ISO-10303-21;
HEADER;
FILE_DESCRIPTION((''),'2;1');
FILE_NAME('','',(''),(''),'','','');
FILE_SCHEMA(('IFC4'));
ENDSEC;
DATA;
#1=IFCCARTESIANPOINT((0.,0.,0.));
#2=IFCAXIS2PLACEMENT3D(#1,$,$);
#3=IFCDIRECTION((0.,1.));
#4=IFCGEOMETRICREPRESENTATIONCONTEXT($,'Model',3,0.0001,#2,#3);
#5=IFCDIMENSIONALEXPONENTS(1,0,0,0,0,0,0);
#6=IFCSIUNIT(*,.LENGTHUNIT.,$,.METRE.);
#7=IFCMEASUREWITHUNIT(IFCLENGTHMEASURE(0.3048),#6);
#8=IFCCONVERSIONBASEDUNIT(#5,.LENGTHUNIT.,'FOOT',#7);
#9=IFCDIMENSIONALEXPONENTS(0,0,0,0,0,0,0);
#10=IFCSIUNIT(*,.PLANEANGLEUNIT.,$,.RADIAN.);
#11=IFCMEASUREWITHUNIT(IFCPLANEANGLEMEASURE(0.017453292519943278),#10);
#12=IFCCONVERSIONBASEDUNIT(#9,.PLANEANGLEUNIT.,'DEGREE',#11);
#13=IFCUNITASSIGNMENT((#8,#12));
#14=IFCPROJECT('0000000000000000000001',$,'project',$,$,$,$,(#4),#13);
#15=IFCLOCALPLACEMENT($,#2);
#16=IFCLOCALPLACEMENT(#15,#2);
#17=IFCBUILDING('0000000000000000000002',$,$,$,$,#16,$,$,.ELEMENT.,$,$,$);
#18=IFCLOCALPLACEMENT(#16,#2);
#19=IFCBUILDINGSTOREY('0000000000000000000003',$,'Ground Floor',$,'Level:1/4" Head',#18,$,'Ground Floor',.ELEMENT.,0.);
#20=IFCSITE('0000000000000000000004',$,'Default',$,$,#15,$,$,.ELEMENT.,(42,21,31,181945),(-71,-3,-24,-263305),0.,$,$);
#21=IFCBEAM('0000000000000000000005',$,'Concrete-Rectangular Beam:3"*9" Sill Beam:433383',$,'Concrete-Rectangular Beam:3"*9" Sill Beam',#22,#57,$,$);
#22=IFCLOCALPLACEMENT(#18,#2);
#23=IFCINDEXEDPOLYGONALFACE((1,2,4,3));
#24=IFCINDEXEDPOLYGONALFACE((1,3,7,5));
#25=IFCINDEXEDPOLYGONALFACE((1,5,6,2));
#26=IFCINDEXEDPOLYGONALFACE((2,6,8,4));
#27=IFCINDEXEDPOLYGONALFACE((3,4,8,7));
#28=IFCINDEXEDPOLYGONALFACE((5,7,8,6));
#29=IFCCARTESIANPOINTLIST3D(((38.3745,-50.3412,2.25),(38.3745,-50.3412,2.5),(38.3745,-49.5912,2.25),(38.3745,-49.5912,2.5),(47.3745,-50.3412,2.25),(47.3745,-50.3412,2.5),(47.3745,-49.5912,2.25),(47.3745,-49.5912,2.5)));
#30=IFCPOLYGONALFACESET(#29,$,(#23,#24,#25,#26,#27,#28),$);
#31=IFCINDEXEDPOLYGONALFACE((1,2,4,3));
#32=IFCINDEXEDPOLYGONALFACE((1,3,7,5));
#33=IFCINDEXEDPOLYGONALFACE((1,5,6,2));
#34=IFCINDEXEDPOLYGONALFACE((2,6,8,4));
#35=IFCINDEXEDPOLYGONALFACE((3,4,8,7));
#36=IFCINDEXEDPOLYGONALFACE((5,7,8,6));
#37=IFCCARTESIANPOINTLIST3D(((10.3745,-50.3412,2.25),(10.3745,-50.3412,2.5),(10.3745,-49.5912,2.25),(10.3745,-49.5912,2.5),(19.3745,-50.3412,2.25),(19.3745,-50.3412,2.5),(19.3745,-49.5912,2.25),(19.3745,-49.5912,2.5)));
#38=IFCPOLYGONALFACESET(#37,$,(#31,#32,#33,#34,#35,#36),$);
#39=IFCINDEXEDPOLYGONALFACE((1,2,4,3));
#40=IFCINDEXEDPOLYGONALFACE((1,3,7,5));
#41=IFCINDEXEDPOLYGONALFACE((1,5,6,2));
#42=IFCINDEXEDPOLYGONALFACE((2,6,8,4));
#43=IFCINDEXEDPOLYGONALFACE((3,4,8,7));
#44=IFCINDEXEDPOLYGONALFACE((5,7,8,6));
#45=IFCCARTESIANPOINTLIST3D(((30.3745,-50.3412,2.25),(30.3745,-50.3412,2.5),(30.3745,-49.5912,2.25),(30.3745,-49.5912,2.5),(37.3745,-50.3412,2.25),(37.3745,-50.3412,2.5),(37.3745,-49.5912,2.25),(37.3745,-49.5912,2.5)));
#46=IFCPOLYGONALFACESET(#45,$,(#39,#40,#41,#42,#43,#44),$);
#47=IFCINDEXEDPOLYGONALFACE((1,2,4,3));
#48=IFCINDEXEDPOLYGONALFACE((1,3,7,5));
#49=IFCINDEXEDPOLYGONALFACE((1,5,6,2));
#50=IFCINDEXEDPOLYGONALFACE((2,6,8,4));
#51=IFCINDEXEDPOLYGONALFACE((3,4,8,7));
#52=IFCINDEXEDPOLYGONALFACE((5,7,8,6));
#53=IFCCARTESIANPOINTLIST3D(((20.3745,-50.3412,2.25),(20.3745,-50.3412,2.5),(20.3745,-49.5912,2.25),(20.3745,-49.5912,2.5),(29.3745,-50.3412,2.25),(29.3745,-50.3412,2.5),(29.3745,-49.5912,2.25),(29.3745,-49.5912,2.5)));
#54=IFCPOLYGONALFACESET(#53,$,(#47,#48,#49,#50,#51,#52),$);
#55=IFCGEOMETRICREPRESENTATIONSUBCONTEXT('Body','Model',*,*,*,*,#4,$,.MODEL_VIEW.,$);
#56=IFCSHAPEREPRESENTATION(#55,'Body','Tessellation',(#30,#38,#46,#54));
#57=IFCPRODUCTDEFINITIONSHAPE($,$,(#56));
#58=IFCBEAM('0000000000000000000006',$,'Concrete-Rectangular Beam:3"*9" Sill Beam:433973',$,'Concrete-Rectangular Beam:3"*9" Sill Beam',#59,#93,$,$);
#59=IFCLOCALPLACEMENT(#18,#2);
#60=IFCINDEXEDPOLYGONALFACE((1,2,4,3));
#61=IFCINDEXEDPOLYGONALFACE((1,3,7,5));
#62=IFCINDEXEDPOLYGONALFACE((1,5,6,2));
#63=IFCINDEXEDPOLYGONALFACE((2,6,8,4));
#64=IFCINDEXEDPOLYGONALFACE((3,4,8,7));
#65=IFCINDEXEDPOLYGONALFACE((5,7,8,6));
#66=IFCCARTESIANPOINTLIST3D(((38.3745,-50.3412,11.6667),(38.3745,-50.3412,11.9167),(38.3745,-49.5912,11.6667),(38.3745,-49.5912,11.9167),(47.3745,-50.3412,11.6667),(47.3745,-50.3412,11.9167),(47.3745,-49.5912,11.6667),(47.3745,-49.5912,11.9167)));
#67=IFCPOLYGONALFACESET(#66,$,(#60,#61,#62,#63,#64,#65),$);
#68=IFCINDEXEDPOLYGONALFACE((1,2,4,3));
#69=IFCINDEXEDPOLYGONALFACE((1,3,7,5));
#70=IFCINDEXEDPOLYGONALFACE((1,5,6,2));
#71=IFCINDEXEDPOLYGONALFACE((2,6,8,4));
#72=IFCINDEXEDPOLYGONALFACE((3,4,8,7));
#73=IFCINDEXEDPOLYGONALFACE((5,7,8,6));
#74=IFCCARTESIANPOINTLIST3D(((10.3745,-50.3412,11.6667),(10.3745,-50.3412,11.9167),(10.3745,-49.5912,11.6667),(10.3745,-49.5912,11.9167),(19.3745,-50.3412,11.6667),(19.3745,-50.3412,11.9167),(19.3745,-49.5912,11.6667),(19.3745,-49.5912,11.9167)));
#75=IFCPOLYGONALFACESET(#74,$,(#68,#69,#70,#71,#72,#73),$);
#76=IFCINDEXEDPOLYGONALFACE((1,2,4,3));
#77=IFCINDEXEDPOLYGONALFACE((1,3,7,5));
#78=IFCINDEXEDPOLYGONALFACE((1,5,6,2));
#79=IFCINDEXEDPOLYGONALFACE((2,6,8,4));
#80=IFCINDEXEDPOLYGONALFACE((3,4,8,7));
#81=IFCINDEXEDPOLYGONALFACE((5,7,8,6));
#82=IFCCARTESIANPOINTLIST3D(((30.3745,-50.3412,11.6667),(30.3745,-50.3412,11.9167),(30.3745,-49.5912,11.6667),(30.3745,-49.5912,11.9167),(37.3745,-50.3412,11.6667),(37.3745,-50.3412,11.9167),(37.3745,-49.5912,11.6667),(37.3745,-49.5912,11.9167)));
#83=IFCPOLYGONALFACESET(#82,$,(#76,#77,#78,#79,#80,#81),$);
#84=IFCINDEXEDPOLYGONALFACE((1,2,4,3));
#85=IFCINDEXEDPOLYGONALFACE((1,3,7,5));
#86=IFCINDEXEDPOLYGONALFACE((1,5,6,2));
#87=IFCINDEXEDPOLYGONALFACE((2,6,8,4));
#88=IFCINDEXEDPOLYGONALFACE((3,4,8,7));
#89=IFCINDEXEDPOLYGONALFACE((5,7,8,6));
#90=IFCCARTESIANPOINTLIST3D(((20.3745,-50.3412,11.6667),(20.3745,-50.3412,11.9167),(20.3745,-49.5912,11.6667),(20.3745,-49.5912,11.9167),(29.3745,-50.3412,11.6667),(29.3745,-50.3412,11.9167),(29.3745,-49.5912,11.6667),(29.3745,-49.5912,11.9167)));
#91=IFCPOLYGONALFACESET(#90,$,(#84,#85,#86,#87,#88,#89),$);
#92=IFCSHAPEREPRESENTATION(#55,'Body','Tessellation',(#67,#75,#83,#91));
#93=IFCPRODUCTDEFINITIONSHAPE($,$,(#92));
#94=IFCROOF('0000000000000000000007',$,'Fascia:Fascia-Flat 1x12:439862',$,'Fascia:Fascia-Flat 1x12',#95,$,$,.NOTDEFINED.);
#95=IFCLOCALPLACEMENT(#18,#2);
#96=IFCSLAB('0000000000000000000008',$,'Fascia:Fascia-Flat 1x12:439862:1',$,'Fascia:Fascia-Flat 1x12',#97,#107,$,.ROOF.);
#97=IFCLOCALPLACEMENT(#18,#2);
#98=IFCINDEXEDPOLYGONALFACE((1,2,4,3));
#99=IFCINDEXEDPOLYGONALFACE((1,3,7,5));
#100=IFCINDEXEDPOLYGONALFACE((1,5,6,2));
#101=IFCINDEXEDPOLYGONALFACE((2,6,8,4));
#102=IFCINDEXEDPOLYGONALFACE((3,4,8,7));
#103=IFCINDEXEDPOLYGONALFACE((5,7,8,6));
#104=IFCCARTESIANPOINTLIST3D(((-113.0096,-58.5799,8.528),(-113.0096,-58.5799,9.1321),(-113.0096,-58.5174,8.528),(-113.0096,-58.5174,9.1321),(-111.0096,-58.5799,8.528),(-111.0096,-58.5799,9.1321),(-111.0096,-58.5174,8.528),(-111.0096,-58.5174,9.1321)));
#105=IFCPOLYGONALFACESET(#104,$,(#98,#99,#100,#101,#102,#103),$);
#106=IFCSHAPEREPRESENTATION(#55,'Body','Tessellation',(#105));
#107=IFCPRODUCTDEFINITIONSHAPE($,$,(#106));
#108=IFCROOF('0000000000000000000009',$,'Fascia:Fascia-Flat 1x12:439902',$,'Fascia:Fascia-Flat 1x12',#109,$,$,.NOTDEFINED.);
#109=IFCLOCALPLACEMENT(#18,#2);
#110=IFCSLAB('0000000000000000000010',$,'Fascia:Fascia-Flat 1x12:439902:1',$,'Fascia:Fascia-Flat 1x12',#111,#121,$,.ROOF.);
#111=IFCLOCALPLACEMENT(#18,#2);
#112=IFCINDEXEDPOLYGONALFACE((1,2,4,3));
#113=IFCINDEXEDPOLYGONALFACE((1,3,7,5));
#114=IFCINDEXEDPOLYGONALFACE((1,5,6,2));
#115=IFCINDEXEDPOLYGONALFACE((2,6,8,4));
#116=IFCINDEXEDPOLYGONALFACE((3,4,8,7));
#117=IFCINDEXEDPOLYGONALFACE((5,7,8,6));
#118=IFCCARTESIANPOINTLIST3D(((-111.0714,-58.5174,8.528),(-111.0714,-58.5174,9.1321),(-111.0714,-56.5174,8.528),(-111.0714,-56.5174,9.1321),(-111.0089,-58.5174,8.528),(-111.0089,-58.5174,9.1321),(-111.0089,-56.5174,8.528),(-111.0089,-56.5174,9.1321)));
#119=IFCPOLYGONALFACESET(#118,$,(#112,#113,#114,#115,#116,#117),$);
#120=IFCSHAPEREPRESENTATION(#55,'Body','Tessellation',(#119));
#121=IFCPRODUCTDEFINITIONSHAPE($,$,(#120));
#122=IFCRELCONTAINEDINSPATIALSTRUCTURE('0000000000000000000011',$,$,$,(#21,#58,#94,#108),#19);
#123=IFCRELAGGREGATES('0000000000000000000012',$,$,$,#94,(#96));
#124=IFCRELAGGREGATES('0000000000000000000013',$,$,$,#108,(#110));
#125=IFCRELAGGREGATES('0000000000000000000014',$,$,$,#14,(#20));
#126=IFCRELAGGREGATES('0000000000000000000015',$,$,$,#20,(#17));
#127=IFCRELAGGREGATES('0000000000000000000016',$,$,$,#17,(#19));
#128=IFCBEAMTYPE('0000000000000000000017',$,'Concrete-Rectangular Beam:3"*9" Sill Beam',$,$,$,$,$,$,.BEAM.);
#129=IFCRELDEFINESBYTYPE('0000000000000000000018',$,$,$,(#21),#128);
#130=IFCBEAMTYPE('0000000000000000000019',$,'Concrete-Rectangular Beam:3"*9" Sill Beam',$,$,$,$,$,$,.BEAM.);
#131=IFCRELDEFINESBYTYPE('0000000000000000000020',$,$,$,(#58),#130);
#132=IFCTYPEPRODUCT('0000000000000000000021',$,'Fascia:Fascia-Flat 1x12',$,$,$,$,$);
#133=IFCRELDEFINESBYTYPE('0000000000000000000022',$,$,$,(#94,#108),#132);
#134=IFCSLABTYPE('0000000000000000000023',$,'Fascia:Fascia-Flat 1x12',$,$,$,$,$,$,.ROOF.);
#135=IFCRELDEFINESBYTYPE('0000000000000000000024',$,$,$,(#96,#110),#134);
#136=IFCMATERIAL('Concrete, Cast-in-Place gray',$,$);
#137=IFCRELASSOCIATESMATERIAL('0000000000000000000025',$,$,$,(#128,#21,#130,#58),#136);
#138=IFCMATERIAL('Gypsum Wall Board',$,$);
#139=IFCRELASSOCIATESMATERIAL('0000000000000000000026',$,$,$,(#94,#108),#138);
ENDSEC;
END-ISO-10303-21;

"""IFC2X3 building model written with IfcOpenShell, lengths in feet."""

from ifc_helpers import new_model, entity, si_unit, converted_unit, direction, frame, frame_2d, origin, origin_2d_with_axis, place, context, subcontext, project, spatial, rectangle, extrude, source, transform, mapped, material, type_object, type_shapes, element, aggregate, save


model = new_model("IFC2X3")

# Units and contexts
model_context = context("Model", 3, precision=0.0001, world=origin(), true_north=direction((0.0, 1.0)))
body_context = subcontext(model_context, "Body", "Model", "MODEL_VIEW")
ifc_project = project(units=[converted_unit("LENGTHUNIT", "FOOT", entity("IfcLengthMeasure", 0.3048), si_unit("LENGTHUNIT", "METRE"), dimensions=[1, 0, 0, 0, 0, 0, 0]), converted_unit("PLANEANGLEUNIT", "DEGREE", entity("IfcPlaneAngleMeasure", 0.017453292519943278), si_unit("PLANEANGLEUNIT", "RADIAN"), dimensions=[0, 0, 0, 0, 0, 0, 0])], contexts=[model_context])

# Site, building, storey
site_placement = place(None, origin())
site = spatial("IfcSite", under=ifc_project, at=site_placement, Name="Default", CompositionType="ELEMENT", RefLatitude=(42, 21, 31, 181945), RefLongitude=(-71, -3, -24, -263305), RefElevation=0.0)
building_placement = place(site_placement, origin())
building = spatial("IfcBuilding", under=site, at=building_placement, CompositionType="ELEMENT")
storey_placement = place(building_placement, origin())
storey = spatial("IfcBuildingStorey", under=building, at=storey_placement, Name="Ground Floor", ObjectType="Level:1/4\" Head", LongName="Ground Floor", CompositionType="ELEMENT", Elevation=0.0)

# Shared definitions
ifc_material_1 = material(Name="Concrete, Cast-in-Place gray")

# Beams
beam_type_1 = type_object("IfcBeamType", Name="Concrete-Rectangular Beam:3\"*9\" Sill Beam", PredefinedType="BEAM", material=ifc_material_1)
shared_shape_1 = source(origin(), body_context, "Body", "SweptSolid", [
    extrude(rectangle(XDim=0.25, YDim=0.75, at=frame_2d((0.0, 0.0), x_axis=(1.0, 0.0))), frame((38.3745, -49.9662, 2.375), z_axis=(1.0, 0.0, 0.0), x_axis=(0.0, 0.0, -1.0)), (0.0, 0.0, 1.0), 9.0),
    extrude(rectangle(XDim=0.25, YDim=0.75, at=frame_2d((0.0, 0.0), x_axis=(1.0, 0.0))), frame((10.3745, -49.9662, 2.375), z_axis=(1.0, 0.0, 0.0), x_axis=(0.0, 0.0, -1.0)), (0.0, 0.0, 1.0), 9.0),
    extrude(rectangle(XDim=0.25, YDim=0.75, at=frame_2d((0.0, 0.0), x_axis=(1.0, 0.0))), frame((30.3745, -49.9662, 2.375), z_axis=(1.0, 0.0, 0.0), x_axis=(0.0, 0.0, -1.0)), (0.0, 0.0, 1.0), 7.0),
    extrude(rectangle(XDim=0.25, YDim=0.75, at=frame_2d((0.0, 0.0), x_axis=(1.0, 0.0))), frame((20.3745, -49.9662, 2.375), z_axis=(1.0, 0.0, 0.0), x_axis=(0.0, 0.0, -1.0)), (0.0, 0.0, 1.0), 9.0),
])
type_shapes(beam_type_1, [shared_shape_1])
beam_1_placement = place(storey_placement, origin())
element("IfcBeam", 1, at=beam_1_placement, inside=storey, type_object=beam_type_1, material=ifc_material_1, Name="Concrete-Rectangular Beam:3\"*9\" Sill Beam:433383", ObjectType="Concrete-Rectangular Beam:3\"*9\" Sill Beam", context=body_context, shape_type="MappedRepresentation", body=[
    mapped(shared_shape_1, transform((0.0, 0.0, 0.0), scale=1.0)),
])
beam_type_2 = type_object("IfcBeamType", Name="Concrete-Rectangular Beam:3\"*9\" Sill Beam", PredefinedType="BEAM", material=ifc_material_1)
shared_shape_2 = source(origin(), body_context, "Body", "SweptSolid", [
    extrude(rectangle(XDim=0.25, YDim=0.75, at=frame_2d((0.0, 0.0), x_axis=(1.0, 0.0))), frame((38.3745, -49.9662, 11.7917), z_axis=(1.0, 0.0, 0.0), x_axis=(0.0, 0.0, -1.0)), (0.0, 0.0, 1.0), 9.0),
    extrude(rectangle(XDim=0.25, YDim=0.75, at=frame_2d((0.0, 0.0), x_axis=(1.0, 0.0))), frame((10.3745, -49.9662, 11.7917), z_axis=(1.0, 0.0, 0.0), x_axis=(0.0, 0.0, -1.0)), (0.0, 0.0, 1.0), 9.0),
    extrude(rectangle(XDim=0.25, YDim=0.75, at=origin_2d_with_axis()), frame((30.3745, -49.9662, 11.7917), z_axis=(1.0, 0.0, 0.0), x_axis=(0.0, 0.0, -1.0)), (0.0, 0.0, 1.0), 7.0),
    extrude(rectangle(XDim=0.25, YDim=0.75, at=origin_2d_with_axis()), frame((20.3745, -49.9662, 11.7917), z_axis=(1.0, 0.0, 0.0), x_axis=(0.0, 0.0, -1.0)), (0.0, 0.0, 1.0), 9.0),
])
type_shapes(beam_type_2, [shared_shape_2])
beam_2_placement = place(storey_placement, origin())
element("IfcBeam", 2, at=beam_2_placement, inside=storey, type_object=beam_type_2, material=ifc_material_1, Name="Concrete-Rectangular Beam:3\"*9\" Sill Beam:433973", ObjectType="Concrete-Rectangular Beam:3\"*9\" Sill Beam", context=body_context, shape_type="MappedRepresentation", body=[
    mapped(shared_shape_2, transform((0.0, 0.0, 0.0), scale=1.0)),
])

# Roofs, slabs
ifc_material_2 = material(Name="Gypsum Wall Board")
type_product_1 = type_object("IfcTypeProduct", Name="Fascia:Fascia-Flat 1x12")
roof_1_placement = place(storey_placement, origin())
roof_1 = element("IfcRoof", 3, at=roof_1_placement, inside=storey, type_object=type_product_1, material=ifc_material_2, Name="Fascia:Fascia-Flat 1x12:439862", ObjectType="Fascia:Fascia-Flat 1x12", ShapeType="NOTDEFINED")
slab_type_1 = type_object("IfcSlabType", Name="Fascia:Fascia-Flat 1x12", PredefinedType="ROOF")
slab_1_placement = place(storey_placement, origin())
slab_1 = element("IfcSlab", 4, at=slab_1_placement, type_object=slab_type_1, Name="Fascia:Fascia-Flat 1x12:439862:1", ObjectType="Fascia:Fascia-Flat 1x12", PredefinedType="ROOF", context=body_context, shape_type="SweptSolid", body=[
    extrude(rectangle(XDim=2.0, YDim=0.0625, at=frame_2d((0.0, 0.0), x_axis=(1.0, 0.0))), frame((-112.0096, -58.5487, 8.528)), (0.0, 0.0, 1.0), 0.6042),
])
aggregate(roof_1, [slab_1])
roof_2_placement = place(storey_placement, origin())
roof_2 = element("IfcRoof", 5, at=roof_2_placement, inside=storey, type_object=type_product_1, material=ifc_material_2, Name="Fascia:Fascia-Flat 1x12:439902", ObjectType="Fascia:Fascia-Flat 1x12", ShapeType="NOTDEFINED")
slab_2_placement = place(storey_placement, origin())
slab_2 = element("IfcSlab", 6, at=slab_2_placement, type_object=slab_type_1, Name="Fascia:Fascia-Flat 1x12:439902:1", ObjectType="Fascia:Fascia-Flat 1x12", PredefinedType="ROOF", context=body_context, shape_type="SweptSolid", body=[
    extrude(rectangle(XDim=2.0, YDim=0.0625, at=origin_2d_with_axis()), frame((-111.0402, -57.5174, 8.528), z_axis=(0.0, 0.0, 1.0), x_axis=(0.0, 1.0, 0.0)), (0.0, 0.0, 1.0), 0.6042),
])
aggregate(roof_2, [slab_2])

save(model, "model.ifc")
